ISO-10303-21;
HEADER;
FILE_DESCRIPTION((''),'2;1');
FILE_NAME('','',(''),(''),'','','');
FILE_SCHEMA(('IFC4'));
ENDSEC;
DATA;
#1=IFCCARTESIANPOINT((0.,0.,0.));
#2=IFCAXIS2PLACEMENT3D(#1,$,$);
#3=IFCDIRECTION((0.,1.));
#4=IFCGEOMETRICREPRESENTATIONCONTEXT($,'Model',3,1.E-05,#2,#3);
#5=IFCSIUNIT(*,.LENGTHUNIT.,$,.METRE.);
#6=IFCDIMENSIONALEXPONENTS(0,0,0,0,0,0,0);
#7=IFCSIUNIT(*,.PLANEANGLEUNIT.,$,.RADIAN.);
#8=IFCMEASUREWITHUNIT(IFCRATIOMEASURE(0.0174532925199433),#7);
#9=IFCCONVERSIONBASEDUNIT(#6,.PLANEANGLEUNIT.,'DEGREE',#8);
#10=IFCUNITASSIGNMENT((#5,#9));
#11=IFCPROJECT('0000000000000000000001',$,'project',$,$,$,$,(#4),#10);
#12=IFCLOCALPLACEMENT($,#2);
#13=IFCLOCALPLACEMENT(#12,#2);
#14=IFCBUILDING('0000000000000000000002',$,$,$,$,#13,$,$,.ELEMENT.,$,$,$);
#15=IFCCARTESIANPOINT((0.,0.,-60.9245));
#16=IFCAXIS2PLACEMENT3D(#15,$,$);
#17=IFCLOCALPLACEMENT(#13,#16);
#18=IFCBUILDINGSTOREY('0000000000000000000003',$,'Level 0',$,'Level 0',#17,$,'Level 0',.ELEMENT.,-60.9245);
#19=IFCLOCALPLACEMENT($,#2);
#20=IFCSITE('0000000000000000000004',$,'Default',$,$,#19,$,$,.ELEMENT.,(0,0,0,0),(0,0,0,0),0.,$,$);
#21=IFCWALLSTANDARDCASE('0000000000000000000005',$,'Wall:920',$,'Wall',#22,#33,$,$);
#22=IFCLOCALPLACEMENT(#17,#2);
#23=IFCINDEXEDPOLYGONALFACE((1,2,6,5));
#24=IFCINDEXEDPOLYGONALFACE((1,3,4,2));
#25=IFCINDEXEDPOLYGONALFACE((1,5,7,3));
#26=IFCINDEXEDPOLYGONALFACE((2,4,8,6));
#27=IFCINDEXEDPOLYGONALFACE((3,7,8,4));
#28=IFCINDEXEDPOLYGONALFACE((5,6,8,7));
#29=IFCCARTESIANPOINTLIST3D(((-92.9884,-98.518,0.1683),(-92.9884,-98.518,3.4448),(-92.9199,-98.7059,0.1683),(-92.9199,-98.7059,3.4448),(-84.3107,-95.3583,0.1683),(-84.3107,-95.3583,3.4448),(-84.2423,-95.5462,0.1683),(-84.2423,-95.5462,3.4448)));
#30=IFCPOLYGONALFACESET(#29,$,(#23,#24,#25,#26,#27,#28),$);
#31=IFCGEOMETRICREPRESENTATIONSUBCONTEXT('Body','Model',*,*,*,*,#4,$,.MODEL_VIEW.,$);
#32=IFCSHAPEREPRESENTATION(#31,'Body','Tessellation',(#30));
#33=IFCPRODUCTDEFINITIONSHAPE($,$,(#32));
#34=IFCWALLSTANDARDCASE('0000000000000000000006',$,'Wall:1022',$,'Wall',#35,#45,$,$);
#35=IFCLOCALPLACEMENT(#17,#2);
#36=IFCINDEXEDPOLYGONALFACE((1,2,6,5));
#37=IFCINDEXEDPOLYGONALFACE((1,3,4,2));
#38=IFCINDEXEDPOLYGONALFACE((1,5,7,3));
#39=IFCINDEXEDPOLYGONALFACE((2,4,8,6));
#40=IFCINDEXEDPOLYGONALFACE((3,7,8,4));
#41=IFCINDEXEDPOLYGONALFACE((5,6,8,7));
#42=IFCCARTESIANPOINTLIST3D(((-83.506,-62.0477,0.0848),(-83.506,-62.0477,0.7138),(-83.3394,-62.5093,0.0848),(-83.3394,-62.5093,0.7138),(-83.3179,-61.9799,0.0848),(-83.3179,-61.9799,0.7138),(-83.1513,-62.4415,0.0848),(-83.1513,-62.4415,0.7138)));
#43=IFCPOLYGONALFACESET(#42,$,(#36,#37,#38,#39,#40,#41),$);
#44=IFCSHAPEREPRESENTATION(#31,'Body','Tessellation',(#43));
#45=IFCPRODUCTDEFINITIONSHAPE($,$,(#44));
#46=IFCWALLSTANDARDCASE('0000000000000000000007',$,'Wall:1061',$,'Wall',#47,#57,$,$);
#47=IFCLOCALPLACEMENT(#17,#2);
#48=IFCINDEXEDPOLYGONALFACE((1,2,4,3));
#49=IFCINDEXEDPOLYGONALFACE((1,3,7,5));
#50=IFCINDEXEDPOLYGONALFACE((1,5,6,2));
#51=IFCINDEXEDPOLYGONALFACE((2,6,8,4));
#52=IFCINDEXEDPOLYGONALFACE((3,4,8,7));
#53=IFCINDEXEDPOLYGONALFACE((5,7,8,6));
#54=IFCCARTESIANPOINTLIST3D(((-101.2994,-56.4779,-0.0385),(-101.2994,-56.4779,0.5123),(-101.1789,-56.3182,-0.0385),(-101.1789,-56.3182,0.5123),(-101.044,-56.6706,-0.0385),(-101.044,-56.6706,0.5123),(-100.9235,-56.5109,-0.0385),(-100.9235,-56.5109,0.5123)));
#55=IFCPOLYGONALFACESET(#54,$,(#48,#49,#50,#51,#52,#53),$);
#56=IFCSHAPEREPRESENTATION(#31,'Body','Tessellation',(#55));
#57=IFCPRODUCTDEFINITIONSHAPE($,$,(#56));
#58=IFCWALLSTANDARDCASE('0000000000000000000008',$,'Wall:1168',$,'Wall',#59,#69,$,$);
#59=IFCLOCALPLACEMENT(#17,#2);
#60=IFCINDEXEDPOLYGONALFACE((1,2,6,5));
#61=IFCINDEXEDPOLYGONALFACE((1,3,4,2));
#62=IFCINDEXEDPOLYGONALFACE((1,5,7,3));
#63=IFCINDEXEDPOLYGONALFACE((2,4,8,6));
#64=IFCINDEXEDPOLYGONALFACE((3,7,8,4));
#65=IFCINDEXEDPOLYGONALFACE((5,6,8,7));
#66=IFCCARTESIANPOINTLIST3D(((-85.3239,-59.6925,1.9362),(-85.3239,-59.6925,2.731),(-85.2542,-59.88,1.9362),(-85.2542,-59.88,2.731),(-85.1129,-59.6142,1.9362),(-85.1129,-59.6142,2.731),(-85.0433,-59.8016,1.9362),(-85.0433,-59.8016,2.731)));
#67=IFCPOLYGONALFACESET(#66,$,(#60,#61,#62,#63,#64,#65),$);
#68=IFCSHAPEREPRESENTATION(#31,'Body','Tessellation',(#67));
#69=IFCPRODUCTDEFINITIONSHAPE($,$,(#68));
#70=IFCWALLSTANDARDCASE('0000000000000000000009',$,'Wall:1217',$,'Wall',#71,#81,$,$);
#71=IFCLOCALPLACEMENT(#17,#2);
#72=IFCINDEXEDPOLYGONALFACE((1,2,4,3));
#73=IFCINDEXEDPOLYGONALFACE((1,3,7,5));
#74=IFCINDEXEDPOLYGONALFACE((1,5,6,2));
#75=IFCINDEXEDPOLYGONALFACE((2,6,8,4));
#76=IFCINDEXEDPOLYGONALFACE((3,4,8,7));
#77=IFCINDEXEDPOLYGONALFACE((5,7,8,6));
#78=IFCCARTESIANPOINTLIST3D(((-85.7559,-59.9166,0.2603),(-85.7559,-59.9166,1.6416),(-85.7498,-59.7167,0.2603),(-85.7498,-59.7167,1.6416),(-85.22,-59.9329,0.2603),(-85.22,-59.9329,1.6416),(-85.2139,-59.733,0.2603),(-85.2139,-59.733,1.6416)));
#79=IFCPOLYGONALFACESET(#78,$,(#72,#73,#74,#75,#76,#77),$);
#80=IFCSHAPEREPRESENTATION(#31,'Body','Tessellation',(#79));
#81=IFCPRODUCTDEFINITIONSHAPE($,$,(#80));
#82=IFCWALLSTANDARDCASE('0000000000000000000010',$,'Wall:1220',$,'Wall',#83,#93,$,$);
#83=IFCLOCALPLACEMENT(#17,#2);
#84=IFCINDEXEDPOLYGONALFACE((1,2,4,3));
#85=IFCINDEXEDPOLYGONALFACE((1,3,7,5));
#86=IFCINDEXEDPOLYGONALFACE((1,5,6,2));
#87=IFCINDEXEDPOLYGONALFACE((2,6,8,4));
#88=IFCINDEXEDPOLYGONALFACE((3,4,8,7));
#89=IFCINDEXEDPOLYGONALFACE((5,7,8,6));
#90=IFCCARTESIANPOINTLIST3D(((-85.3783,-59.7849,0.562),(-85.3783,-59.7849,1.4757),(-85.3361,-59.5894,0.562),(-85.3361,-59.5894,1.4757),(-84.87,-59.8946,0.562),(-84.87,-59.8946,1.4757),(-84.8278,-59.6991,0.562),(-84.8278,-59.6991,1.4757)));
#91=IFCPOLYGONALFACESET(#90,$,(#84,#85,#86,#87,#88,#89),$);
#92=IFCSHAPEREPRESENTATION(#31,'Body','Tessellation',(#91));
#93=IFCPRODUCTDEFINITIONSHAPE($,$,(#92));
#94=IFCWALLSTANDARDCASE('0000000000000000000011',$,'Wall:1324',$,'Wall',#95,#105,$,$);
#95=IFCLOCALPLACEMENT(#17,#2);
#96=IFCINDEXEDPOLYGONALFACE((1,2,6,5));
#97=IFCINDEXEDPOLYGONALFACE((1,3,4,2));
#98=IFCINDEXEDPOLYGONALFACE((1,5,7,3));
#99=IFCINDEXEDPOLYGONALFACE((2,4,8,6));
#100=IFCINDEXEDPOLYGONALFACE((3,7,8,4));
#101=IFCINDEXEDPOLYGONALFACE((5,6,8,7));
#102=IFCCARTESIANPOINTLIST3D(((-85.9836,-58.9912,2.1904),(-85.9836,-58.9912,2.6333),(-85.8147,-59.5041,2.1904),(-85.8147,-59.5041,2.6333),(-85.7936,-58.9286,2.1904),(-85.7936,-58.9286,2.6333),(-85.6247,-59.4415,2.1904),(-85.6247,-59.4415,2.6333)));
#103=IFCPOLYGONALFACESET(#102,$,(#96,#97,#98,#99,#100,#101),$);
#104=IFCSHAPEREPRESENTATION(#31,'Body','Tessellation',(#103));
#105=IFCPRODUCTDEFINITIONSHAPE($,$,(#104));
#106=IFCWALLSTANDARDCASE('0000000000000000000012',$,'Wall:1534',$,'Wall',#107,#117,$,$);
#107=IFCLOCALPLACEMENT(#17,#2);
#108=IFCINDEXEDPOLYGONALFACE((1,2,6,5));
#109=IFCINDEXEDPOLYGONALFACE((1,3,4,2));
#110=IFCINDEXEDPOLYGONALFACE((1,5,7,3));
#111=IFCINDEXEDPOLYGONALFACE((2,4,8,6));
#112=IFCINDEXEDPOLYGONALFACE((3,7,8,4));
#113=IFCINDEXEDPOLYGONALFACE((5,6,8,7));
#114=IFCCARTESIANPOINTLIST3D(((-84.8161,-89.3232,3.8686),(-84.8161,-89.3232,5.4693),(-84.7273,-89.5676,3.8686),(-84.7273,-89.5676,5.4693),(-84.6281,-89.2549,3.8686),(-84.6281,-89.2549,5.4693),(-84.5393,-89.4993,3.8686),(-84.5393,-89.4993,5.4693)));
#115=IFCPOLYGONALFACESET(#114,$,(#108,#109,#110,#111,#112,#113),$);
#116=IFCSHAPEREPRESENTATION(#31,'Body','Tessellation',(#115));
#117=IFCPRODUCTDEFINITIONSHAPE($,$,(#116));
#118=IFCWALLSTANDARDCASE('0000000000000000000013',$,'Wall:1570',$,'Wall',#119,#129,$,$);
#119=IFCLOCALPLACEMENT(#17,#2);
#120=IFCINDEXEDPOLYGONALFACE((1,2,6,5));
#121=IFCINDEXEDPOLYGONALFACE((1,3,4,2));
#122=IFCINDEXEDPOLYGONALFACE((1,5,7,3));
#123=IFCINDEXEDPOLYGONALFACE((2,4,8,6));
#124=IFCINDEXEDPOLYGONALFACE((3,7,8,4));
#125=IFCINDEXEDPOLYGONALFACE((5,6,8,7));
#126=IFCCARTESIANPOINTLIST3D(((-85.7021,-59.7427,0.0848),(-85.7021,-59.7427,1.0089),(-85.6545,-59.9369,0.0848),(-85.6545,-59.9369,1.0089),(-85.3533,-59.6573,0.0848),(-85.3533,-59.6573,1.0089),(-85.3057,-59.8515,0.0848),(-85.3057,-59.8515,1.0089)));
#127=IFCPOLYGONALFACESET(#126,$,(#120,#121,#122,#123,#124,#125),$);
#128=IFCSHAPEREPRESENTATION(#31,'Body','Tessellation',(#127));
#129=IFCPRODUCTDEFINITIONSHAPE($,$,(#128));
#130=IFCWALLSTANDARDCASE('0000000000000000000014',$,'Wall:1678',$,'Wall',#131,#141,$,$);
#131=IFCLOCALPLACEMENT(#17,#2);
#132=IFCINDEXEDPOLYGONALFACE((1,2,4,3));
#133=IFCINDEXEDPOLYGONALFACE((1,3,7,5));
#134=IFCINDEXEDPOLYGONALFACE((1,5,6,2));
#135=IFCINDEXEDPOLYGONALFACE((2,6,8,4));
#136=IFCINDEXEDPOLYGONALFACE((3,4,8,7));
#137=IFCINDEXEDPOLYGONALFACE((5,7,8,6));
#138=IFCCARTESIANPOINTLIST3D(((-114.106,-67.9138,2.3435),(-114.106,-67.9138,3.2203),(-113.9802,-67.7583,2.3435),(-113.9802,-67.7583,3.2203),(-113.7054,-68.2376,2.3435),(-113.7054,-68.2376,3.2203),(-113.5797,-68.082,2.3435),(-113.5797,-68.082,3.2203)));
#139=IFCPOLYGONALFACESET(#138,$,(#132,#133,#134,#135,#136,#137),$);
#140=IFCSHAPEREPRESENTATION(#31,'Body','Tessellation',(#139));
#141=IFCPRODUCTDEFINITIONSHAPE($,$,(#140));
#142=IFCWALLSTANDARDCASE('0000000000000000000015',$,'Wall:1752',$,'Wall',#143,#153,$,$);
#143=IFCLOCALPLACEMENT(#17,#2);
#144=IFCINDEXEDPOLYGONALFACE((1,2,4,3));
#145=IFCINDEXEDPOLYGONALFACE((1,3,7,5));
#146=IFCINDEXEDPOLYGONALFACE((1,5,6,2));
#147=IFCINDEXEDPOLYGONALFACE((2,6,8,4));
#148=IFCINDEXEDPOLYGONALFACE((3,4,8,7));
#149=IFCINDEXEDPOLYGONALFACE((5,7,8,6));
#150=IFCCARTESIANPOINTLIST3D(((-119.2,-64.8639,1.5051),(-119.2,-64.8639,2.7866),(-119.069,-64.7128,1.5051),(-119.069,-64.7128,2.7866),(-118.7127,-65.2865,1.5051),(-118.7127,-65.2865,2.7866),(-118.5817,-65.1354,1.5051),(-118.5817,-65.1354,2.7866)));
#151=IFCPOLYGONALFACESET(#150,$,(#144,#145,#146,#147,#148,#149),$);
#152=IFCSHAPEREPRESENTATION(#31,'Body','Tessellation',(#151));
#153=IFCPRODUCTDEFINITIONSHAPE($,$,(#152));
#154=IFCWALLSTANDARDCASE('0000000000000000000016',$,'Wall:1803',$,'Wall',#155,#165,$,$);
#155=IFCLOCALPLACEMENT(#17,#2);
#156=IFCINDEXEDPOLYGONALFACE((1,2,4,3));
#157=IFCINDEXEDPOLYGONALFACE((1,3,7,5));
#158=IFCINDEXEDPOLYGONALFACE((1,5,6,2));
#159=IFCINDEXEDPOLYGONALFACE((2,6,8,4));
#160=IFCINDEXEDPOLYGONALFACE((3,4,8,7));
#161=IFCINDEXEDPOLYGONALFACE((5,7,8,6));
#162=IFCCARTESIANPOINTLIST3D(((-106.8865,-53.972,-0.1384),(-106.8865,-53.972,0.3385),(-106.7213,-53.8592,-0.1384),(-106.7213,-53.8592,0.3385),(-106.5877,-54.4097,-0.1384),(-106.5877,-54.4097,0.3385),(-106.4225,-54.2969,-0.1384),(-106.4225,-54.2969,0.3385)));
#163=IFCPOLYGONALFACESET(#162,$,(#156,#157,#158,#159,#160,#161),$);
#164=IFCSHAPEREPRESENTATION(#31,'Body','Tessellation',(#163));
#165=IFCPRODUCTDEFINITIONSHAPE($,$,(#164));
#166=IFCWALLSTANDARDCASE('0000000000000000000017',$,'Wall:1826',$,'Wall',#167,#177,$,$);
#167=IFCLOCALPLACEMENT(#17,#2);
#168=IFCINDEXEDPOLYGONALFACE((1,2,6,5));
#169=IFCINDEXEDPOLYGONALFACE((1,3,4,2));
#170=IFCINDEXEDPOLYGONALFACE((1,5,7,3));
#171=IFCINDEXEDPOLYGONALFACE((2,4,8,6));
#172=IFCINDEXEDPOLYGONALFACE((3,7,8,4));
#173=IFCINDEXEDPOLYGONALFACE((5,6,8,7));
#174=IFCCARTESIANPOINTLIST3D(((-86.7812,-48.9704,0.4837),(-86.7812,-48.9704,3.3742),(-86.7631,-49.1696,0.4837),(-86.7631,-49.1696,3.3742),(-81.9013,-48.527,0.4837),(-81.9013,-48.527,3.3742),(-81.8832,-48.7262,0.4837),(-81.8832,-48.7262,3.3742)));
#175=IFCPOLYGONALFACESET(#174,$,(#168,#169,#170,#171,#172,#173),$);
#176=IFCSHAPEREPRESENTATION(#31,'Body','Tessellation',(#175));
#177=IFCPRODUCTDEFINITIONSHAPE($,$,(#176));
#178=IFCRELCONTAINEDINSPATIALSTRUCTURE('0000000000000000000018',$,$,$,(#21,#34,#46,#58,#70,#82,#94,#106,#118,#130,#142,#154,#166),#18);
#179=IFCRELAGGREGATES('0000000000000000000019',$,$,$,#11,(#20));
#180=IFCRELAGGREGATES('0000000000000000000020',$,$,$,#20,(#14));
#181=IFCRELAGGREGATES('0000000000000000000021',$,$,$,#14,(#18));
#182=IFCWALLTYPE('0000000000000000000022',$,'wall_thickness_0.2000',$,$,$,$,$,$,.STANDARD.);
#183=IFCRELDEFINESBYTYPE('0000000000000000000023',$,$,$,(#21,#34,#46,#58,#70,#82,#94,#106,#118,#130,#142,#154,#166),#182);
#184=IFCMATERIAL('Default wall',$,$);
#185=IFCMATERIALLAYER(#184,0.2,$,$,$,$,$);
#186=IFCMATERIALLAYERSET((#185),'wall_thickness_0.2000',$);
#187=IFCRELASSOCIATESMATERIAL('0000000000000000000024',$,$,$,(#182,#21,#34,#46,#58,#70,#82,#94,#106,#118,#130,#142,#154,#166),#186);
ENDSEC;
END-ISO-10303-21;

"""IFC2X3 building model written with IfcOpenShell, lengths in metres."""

from ifc_helpers import new_model, entity, si_unit, converted_unit, direction, frame, origin, place, context, subcontext, project, spatial, polyline, outline, extrude, material, layer, layer_set, layer_usage, type_object, element, save


model = new_model("IFC2X3")

# Units and contexts
model_context = context("Model", 3, precision=1e-05, world=origin(), true_north=direction((0.0, 1.0)))
body_context = subcontext(model_context, "Body", "Model", "MODEL_VIEW")
ifc_project = project(units=[si_unit("LENGTHUNIT", "METRE"), converted_unit("PLANEANGLEUNIT", "DEGREE", entity("IfcRatioMeasure", 0.0174532925199433), si_unit("PLANEANGLEUNIT", "RADIAN"), dimensions=[0, 0, 0, 0, 0, 0, 0])], contexts=[model_context])

# Site, building, storey
site_placement = place(None, origin())
site = spatial("IfcSite", under=ifc_project, at=site_placement, Name="Default", CompositionType="ELEMENT", RefLatitude=(0, 0, 0, 0), RefLongitude=(0, 0, 0, 0), RefElevation=0.0)
placement_1 = place(None, origin())
building_placement = place(placement_1, origin())
building = spatial("IfcBuilding", under=site, at=building_placement, CompositionType="ELEMENT")
storey_placement = place(building_placement, frame((0.0, 0.0, -60.9245)))
storey = spatial("IfcBuildingStorey", under=building, at=storey_placement, Name="Level 0", ObjectType="Level 0", LongName="Level 0", CompositionType="ELEMENT", Elevation=-60.9245)

# Walls
ifc_material = material(Name="Default wall")
ifc_layer = layer(ifc_material, 0.2)
ifc_layer_set = layer_set([ifc_layer], Name="wall_thickness_0.2000")
ifc_layer_usage = layer_usage(ifc_layer_set, "AXIS2", "POSITIVE", -0.1)
wall_type = type_object("IfcWallType", Name="wall_thickness_0.2000", PredefinedType="STANDARD", material=ifc_layer_set)
placement_2 = place(building_placement, frame((0.0, 0.0, -60.7562)))
wall_1_placement = place(placement_2, frame((-92.9541, -98.6119, 0.0), z_axis=(0.0, 0.0, 1.0), x_axis=(0.939649, 0.34214, 0.0)))
element("IfcWallStandardCase", 1, at=wall_1_placement, inside=storey, type_object=wall_type, material=ifc_layer_usage, Name="Wall:920", ObjectType="Wall", context=body_context, shape_type="SweptSolid", body=[
    extrude(outline(polyline([(9.235, -0.1), (9.235, 0.1), (0.0, 0.1), (0.0, -0.1), (9.235, -0.1)])), origin(), (0.0, 0.0, 1.0), 3.2765),
])
placement_3 = place(building_placement, frame((0.0, 0.0, -60.8397)))
wall_2_placement = place(placement_3, frame((-83.2454, -62.4754, 0.0), z_axis=(0.0, 0.0, 1.0), x_axis=(-0.339434, 0.94063, 0.0)))
element("IfcWallStandardCase", 2, at=wall_2_placement, inside=storey, type_object=wall_type, material=ifc_layer_usage, Name="Wall:1022", ObjectType="Wall", context=body_context, shape_type="SweptSolid", body=[
    extrude(outline(polyline([(0.4907, -0.1), (0.4907, 0.1), (0.0, 0.1), (0.0, -0.1), (0.4907, -0.1)])), origin(), (0.0, 0.0, 1.0), 0.629),
])
placement_4 = place(building_placement, frame((0.0, 0.0, -60.963)))
wall_3_placement = place(placement_4, frame((-100.9837, -56.5908, 0.0), z_axis=(0.0, 0.0, 1.0), x_axis=(-0.798274, 0.602294, 0.0)))
element("IfcWallStandardCase", 3, at=wall_3_placement, inside=storey, type_object=wall_type, material=ifc_layer_usage, Name="Wall:1061", ObjectType="Wall", context=body_context, shape_type="SweptSolid", body=[
    extrude(outline(polyline([(0.32, -0.1), (0.32, 0.1), (0.0, 0.1), (0.0, -0.1), (0.32, -0.1)])), origin(), (0.0, 0.0, 1.0), 0.5508),
])
placement_5 = place(building_placement, frame((0.0, 0.0, -58.9883)))
wall_4_placement = place(placement_5, frame((-85.0781, -59.7079, 0.0), z_axis=(0.0, 0.0, 1.0), x_axis=(-0.937431, -0.348171, 0.0)))
element("IfcWallStandardCase", 4, at=wall_4_placement, inside=storey, type_object=wall_type, material=ifc_layer_usage, Name="Wall:1168", ObjectType="Wall", context=body_context, shape_type="SweptSolid", body=[
    extrude(outline(polyline([(0.225, -0.1), (0.225, 0.1), (0.0, 0.1), (0.0, -0.1), (0.225, -0.1)])), origin(), (0.0, 0.0, 1.0), 0.7948),
])
placement_6 = place(building_placement, frame((0.0, 0.0, -60.6642)))
wall_5_placement = place(placement_6, frame((-85.217, -59.833, 0.0), z_axis=(0.0, 0.0, 1.0), x_axis=(-0.999535, 0.030488, 0.0)))
element("IfcWallStandardCase", 5, at=wall_5_placement, inside=storey, type_object=wall_type, material=ifc_layer_usage, Name="Wall:1217", ObjectType="Wall", context=body_context, shape_type="SweptSolid", body=[
    extrude(outline(polyline([(0.5361, -0.1), (0.5361, 0.1), (0.0, 0.1), (0.0, -0.1), (0.5361, -0.1)])), origin(), (0.0, 0.0, 1.0), 1.3813),
])
placement_7 = place(building_placement, frame((0.0, 0.0, -60.3625)))
wall_6_placement = place(placement_7, frame((-84.8489, -59.7969, 0.0), z_axis=(0.0, 0.0, 1.0), x_axis=(-0.977481, 0.211025, 0.0)))
element("IfcWallStandardCase", 6, at=wall_6_placement, inside=storey, type_object=wall_type, material=ifc_layer_usage, Name="Wall:1220", ObjectType="Wall", context=body_context, shape_type="SweptSolid", body=[
    extrude(outline(polyline([(0.52, -0.1), (0.52, 0.1), (0.0, 0.1), (0.0, -0.1), (0.52, -0.1)])), origin(), (0.0, 0.0, 1.0), 0.9137),
])
placement_8 = place(building_placement, frame((0.0, 0.0, -58.7341)))
wall_7_placement = place(placement_8, frame((-85.8886, -58.9599, 0.0), z_axis=(0.0, 0.0, 1.0), x_axis=(0.31279, -0.949822, 0.0)))
element("IfcWallStandardCase", 7, at=wall_7_placement, inside=storey, type_object=wall_type, material=ifc_layer_usage, Name="Wall:1324", ObjectType="Wall", context=body_context, shape_type="SweptSolid", body=[
    extrude(outline(polyline([(0.54, -0.1), (0.54, 0.1), (0.0, 0.1), (0.0, -0.1), (0.54, -0.1)])), origin(), (0.0, 0.0, 1.0), 0.4429),
])
placement_9 = place(building_placement, frame((0.0, 0.0, -57.0559)))
wall_8_placement = place(placement_9, frame((-84.6333, -89.5334, 0.0), z_axis=(0.0, 0.0, 1.0), x_axis=(-0.341416, 0.939912, 0.0)))
element("IfcWallStandardCase", 8, at=wall_8_placement, inside=storey, type_object=wall_type, material=ifc_layer_usage, Name="Wall:1534", ObjectType="Wall", context=body_context, shape_type="SweptSolid", body=[
    extrude(outline(polyline([(0.26, -0.1), (0.26, 0.1), (0.0, 0.1), (0.0, -0.1), (0.26, -0.1)])), origin(), (0.0, 0.0, 1.0), 1.6007),
])
placement_10 = place(building_placement, frame((0.0, 0.0, -60.8397)))
wall_9_placement = place(placement_10, frame((-85.3295, -59.7544, 0.0), z_axis=(0.0, 0.0, 1.0), x_axis=(-0.971304, -0.237839, 0.0)))
element("IfcWallStandardCase", 9, at=wall_9_placement, inside=storey, type_object=wall_type, material=ifc_layer_usage, Name="Wall:1570", ObjectType="Wall", context=body_context, shape_type="SweptSolid", body=[
    extrude(outline(polyline([(0.3592, -0.1), (0.3592, 0.1), (0.0, 0.1), (0.0, -0.1), (0.3592, -0.1)])), origin(), (0.0, 0.0, 1.0), 0.9242),
])
placement_11 = place(building_placement, frame((0.0, 0.0, -58.581)))
wall_10_placement = place(placement_11, frame((-113.6426, -68.1598, 0.0), z_axis=(0.0, 0.0, 1.0), x_axis=(-0.777739, 0.628588, 0.0)))
element("IfcWallStandardCase", 10, at=wall_10_placement, inside=storey, type_object=wall_type, material=ifc_layer_usage, Name="Wall:1678", ObjectType="Wall", context=body_context, shape_type="SweptSolid", body=[
    extrude(outline(polyline([(0.515, -0.1), (0.515, 0.1), (0.0, 0.1), (0.0, -0.1), (0.515, -0.1)])), origin(), (0.0, 0.0, 1.0), 0.8768),
])
placement_12 = place(building_placement, frame((0.0, 0.0, -59.4194)))
wall_11_placement = place(placement_12, frame((-118.6472, -65.2109, 0.0), z_axis=(0.0, 0.0, 1.0), x_axis=(-0.755523, 0.655122, 0.0)))
element("IfcWallStandardCase", 11, at=wall_11_placement, inside=storey, type_object=wall_type, material=ifc_layer_usage, Name="Wall:1752", ObjectType="Wall", context=body_context, shape_type="SweptSolid", body=[
    extrude(outline(polyline([(0.645, -0.1), (0.645, 0.1), (0.0, 0.1), (0.0, -0.1), (0.645, -0.1)])), origin(), (0.0, 0.0, 1.0), 1.2815),
])
placement_13 = place(building_placement, frame((0.0, 0.0, -61.0629)))
wall_12_placement = place(placement_13, frame((-106.8039, -53.9156, 0.0), z_axis=(0.0, 0.0, 1.0), x_axis=(0.563825, -0.825894, 0.0)))
element("IfcWallStandardCase", 12, at=wall_12_placement, inside=storey, type_object=wall_type, material=ifc_layer_usage, Name="Wall:1803", ObjectType="Wall", context=body_context, shape_type="SweptSolid", body=[
    extrude(outline(polyline([(0.53, -0.1), (0.53, 0.1), (0.0, 0.1), (0.0, -0.1), (0.53, -0.1)])), origin(), (0.0, 0.0, 1.0), 0.4769),
])
placement_14 = place(building_placement, frame((0.0, 0.0, -60.4408)))
wall_13_placement = place(placement_14, frame((-86.7721, -49.07, 0.0), z_axis=(0.0, 0.0, 1.0), x_axis=(0.995898, 0.090479, 0.0)))
element("IfcWallStandardCase", 13, at=wall_13_placement, inside=storey, type_object=wall_type, material=ifc_layer_usage, Name="Wall:1826", ObjectType="Wall", context=body_context, shape_type="SweptSolid", body=[
    extrude(outline(polyline([(4.9, -0.1), (4.9, 0.1), (0.0, 0.1), (0.0, -0.1), (4.9, -0.1)])), origin(), (0.0, 0.0, 1.0), 2.8905),
])

save(model, "model.ifc")
